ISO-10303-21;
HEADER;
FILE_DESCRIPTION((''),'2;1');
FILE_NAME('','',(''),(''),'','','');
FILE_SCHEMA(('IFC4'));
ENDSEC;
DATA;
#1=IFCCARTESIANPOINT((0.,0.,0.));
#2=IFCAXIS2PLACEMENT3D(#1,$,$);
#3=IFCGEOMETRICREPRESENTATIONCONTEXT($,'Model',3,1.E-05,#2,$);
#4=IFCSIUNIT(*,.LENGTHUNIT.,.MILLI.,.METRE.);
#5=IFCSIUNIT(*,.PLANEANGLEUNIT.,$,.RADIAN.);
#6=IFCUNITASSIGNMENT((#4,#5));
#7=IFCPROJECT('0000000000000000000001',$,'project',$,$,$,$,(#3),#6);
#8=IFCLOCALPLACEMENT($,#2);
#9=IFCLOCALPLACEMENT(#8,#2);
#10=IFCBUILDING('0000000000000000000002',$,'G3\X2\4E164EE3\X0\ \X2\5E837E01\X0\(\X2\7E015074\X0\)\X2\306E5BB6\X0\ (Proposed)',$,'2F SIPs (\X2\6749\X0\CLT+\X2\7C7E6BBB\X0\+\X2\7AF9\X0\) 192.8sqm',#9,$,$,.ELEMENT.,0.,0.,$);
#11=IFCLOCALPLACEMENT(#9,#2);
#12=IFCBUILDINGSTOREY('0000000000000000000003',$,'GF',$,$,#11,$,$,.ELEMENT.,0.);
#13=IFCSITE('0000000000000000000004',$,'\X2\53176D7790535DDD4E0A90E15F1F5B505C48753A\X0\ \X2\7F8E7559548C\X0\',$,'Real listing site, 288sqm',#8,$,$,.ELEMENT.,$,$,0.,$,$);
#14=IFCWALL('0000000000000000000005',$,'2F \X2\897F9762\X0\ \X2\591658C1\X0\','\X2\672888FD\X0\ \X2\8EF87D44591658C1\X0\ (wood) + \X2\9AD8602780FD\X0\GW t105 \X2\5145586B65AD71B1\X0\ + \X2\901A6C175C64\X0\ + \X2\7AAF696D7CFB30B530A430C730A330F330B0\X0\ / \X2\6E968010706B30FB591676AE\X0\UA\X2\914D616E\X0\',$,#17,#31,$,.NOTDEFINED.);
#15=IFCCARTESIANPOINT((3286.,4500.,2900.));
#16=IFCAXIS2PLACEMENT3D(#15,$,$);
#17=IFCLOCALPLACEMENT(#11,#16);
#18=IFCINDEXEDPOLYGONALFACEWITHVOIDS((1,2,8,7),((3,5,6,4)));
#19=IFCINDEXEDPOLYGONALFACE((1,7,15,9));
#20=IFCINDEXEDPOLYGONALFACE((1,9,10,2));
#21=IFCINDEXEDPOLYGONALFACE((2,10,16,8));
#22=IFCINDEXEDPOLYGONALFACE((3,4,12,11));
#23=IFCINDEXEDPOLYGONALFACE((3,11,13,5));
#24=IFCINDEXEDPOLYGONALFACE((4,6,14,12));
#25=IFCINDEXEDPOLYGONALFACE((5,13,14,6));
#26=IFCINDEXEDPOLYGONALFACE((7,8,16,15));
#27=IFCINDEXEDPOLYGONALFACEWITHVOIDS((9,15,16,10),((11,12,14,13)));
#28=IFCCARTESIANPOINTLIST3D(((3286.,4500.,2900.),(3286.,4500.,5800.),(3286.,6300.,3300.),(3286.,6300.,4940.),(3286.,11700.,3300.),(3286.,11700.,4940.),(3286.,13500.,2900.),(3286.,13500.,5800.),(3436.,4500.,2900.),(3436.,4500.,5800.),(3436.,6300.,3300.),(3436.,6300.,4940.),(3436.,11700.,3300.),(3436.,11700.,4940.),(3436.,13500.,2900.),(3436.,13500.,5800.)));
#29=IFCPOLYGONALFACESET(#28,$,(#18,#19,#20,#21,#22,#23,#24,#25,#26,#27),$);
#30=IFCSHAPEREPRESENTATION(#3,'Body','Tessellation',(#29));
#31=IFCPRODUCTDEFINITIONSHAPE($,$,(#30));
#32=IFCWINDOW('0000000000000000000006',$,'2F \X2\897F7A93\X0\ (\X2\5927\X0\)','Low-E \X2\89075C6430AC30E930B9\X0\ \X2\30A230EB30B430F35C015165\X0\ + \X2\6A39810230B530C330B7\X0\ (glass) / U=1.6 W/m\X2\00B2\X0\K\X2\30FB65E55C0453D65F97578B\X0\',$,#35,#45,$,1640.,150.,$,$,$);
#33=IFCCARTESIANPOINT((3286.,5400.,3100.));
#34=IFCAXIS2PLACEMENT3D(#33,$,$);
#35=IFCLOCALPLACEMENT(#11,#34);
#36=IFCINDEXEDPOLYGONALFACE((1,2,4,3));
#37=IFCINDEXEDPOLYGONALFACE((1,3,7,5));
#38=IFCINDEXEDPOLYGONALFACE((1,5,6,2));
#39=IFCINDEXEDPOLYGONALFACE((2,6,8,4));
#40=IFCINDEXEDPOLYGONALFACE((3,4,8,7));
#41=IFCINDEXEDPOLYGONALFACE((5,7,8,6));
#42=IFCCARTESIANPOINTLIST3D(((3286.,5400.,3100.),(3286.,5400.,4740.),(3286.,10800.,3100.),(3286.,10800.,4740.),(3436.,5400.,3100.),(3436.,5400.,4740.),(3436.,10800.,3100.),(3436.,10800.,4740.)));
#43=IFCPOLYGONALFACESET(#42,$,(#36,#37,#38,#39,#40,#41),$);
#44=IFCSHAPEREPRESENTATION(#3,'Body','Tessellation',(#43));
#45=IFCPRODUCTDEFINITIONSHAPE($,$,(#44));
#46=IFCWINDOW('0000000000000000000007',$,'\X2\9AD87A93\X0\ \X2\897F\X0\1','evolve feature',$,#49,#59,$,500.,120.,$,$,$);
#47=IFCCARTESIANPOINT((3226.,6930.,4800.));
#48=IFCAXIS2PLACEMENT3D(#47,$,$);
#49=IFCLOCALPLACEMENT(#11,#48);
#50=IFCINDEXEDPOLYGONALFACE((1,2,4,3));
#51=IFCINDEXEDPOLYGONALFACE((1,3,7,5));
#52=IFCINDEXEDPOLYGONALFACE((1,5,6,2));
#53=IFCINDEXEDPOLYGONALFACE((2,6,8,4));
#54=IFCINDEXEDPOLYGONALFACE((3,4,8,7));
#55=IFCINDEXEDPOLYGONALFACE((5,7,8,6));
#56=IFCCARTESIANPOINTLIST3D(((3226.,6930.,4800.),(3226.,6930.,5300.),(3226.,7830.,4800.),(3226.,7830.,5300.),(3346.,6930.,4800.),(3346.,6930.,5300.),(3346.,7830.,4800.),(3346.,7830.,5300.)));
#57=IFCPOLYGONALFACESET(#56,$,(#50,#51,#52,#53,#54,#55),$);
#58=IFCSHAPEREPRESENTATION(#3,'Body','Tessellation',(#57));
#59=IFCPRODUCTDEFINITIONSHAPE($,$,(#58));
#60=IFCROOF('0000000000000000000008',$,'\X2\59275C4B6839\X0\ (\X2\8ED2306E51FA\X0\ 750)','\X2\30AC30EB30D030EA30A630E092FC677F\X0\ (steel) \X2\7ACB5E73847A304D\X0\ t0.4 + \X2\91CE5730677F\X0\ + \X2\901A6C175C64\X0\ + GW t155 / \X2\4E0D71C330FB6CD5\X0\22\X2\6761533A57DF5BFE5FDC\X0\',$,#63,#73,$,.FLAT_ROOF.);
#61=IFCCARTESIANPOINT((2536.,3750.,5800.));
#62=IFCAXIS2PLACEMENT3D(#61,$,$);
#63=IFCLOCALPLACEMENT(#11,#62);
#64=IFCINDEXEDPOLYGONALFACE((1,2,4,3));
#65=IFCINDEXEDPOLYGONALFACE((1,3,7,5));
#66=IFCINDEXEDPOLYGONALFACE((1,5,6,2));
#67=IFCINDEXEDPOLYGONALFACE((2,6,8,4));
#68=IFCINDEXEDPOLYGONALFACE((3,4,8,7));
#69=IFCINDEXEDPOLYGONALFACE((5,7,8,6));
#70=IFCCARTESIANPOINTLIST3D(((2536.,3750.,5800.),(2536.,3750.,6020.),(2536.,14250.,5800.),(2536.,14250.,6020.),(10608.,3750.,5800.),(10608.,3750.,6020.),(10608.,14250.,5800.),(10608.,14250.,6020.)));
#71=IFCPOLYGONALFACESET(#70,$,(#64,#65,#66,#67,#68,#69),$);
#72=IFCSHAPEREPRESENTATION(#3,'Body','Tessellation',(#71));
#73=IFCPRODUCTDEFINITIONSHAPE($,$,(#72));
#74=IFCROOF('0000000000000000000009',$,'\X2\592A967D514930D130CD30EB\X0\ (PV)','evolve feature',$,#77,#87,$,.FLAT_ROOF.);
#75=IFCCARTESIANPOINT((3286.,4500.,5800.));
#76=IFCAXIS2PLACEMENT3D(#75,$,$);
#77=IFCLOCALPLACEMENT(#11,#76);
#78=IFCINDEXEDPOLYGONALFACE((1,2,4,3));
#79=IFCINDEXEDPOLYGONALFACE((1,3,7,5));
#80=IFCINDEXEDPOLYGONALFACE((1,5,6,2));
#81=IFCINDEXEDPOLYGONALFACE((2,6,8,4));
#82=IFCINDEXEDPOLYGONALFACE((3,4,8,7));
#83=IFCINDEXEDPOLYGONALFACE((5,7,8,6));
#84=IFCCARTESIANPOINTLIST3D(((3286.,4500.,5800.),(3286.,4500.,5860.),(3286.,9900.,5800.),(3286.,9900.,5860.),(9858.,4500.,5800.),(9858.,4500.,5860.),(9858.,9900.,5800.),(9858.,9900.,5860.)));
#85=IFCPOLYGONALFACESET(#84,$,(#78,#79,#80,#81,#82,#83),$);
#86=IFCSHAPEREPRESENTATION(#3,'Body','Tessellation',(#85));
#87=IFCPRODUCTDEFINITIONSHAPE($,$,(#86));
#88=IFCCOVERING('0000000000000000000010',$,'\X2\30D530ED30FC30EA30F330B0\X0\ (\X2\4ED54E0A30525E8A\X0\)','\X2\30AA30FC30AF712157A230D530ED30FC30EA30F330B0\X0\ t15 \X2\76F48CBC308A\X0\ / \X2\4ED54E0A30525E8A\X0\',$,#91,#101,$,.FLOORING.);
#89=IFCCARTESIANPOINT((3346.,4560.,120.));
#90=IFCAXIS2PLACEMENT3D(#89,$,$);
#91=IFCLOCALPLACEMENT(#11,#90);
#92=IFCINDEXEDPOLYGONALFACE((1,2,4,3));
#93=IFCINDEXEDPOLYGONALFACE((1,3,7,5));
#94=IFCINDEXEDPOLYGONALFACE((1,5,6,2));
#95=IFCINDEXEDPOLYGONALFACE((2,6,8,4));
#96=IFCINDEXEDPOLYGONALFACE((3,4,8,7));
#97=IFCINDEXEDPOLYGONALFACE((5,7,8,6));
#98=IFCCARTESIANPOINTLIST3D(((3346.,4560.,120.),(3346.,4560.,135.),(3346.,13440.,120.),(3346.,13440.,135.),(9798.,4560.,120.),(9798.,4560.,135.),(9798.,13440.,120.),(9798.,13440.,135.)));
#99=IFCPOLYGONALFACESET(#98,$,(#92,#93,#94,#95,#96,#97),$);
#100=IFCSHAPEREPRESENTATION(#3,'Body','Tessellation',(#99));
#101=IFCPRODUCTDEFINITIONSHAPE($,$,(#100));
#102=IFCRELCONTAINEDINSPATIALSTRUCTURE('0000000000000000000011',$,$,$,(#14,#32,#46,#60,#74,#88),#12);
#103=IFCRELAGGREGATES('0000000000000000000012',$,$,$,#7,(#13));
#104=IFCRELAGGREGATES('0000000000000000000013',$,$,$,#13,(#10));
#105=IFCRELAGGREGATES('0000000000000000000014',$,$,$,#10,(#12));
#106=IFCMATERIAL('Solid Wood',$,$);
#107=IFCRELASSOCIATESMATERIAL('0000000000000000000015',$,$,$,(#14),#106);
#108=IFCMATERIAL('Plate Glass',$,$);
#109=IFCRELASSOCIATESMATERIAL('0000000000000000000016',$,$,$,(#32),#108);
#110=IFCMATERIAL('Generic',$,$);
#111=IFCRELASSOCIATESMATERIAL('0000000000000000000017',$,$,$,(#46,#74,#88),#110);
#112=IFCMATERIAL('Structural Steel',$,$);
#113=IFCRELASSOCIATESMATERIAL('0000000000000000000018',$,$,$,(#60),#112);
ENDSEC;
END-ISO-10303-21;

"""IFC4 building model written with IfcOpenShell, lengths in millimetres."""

from ifc_helpers import new_model, si_unit, frame, frame_2d, origin, place, context, project, spatial, rectangle, extrude, material, element, fill, save


model = new_model("IFC4")

# Units and contexts
model_context = context("Model", 3, precision=1e-05, world=origin())
ifc_project = project(units=[si_unit("LENGTHUNIT", "METRE", prefix="MILLI"), si_unit("PLANEANGLEUNIT", "RADIAN")], contexts=[model_context])

# Site, building, storey
site_placement = place(None, origin())
site = spatial("IfcSite", under=ifc_project, at=site_placement, Name="北海道川上郡弟子屈町 美留和", ObjectType="Real listing site, 288sqm", CompositionType="ELEMENT", RefElevation=0.0)
building_placement = place(site_placement, origin())
building = spatial("IfcBuilding", under=site, at=building_placement, Name="G3世代 広縁(縁側)の家 (Proposed)", ObjectType="2F SIPs (杉CLT+籾殻+竹) 192.8sqm", CompositionType="ELEMENT", ElevationOfRefHeight=0.0, ElevationOfTerrain=0.0)
storey_placement = place(building_placement, origin())
storey = spatial("IfcBuildingStorey", under=building, at=storey_placement, Name="GF", CompositionType="ELEMENT", Elevation=0.0)

# Shared definitions
ifc_material_1 = material(Name="Solid Wood")

# Shared definitions
ifc_material_2 = material(Name="Plate Glass")
ifc_material_3 = material(Name="Generic")

# Wall, openings, windows
wall_1_placement = place(storey_placement, frame((3286.0, 4500.0, 2900.0)))
wall_1 = element("IfcWall", 1, at=wall_1_placement, inside=storey, material=ifc_material_1, Name="2F 西面 外壁", Description="木製 軸組外壁 (wood) + 高性能GW t105 充填断熱 + 通気層 + 窯業系サイディング / 準耐火・外皮UA配慮", PredefinedType="NOTDEFINED", context=model_context, shape_type="SweptSolid", body=[
    extrude(rectangle(XDim=150.0, YDim=9000.0, at=frame_2d((75.0, 4500.0))), frame((3286.0, 4500.0, 2900.0)), (0.0, 0.0, 1.0), 2900.0),
])
opening_1_placement = place(storey_placement, frame((3286.0, 5400.0, 3100.0)))
opening_1 = element("IfcOpeningElement", 2, at=opening_1_placement, cuts=wall_1, PredefinedType="NOTDEFINED", context=model_context, shape_type="SweptSolid", body=[
    extrude(rectangle(XDim=150.0, YDim=5400.0, at=frame_2d((75.0, 2700.0))), frame((3286.0, 5400.0, 3100.0)), (0.0, 0.0, 1.0), 1640.0),
])
opening_2_placement = place(storey_placement, frame((3226.0, 6930.0, 4800.0)))
opening_2 = element("IfcOpeningElement", 3, at=opening_2_placement, cuts=wall_1, PredefinedType="NOTDEFINED", context=model_context, shape_type="SweptSolid", body=[
    extrude(rectangle(XDim=120.0, YDim=900.0, at=frame_2d((60.0, 450.0))), frame((3226.0, 6930.0, 4800.0)), (0.0, 0.0, 1.0), 500.0),
])
window_1_placement = place(storey_placement, frame((3286.0, 5400.0, 3100.0)))
window_1 = element("IfcWindow", 4, at=window_1_placement, inside=storey, material=ifc_material_2, Name="2F 西窓 (大)", Description="Low-E 複層ガラス アルゴン封入 + 樹脂サッシ (glass) / U=1.6 W/m²K・日射取得型", OverallHeight=1640.0, OverallWidth=150.0, context=model_context, shape_type="SweptSolid", body=[
    extrude(rectangle(XDim=150.0, YDim=5400.0, at=frame_2d((75.0, 2700.0))), frame((3286.0, 5400.0, 3100.0)), (0.0, 0.0, 1.0), 1640.0),
])
fill(opening_1, window_1)
window_2_placement = place(storey_placement, frame((3226.0, 6930.0, 4800.0)))
window_2 = element("IfcWindow", 5, at=window_2_placement, inside=storey, material=ifc_material_3, Name="高窓 西1", Description="evolve feature", OverallHeight=500.0, OverallWidth=120.0, context=model_context, shape_type="SweptSolid", body=[
    extrude(rectangle(XDim=120.0, YDim=900.0, at=frame_2d((60.0, 450.0))), frame((3226.0, 6930.0, 4800.0)), (0.0, 0.0, 1.0), 500.0),
])
fill(opening_2, window_2)

# Roofs
ifc_material_4 = material(Name="Structural Steel")
roof_1_placement = place(storey_placement, frame((2536.0, 3750.0, 5800.0)))
element("IfcRoof", 6, at=roof_1_placement, inside=storey, material=ifc_material_4, Name="大屋根 (軒の出 750)", Description="ガルバリウム鋼板 (steel) 立平葺き t0.4 + 野地板 + 通気層 + GW t155 / 不燃・法22条区域対応", PredefinedType="FLAT_ROOF", context=model_context, shape_type="SweptSolid", body=[
    extrude(rectangle(XDim=8072.0, YDim=10500.0, at=frame_2d((4036.0, 5250.0))), frame((2536.0, 3750.0, 5800.0)), (0.0, 0.0, 1.0), 220.0),
])
roof_2_placement = place(storey_placement, frame((3286.0, 4500.0, 5800.0)))
element("IfcRoof", 7, at=roof_2_placement, inside=storey, material=ifc_material_3, Name="太陽光パネル (PV)", Description="evolve feature", PredefinedType="FLAT_ROOF", context=model_context, shape_type="SweptSolid", body=[
    extrude(rectangle(XDim=6572.0, YDim=5400.0, at=frame_2d((3286.0, 2700.0))), frame((3286.0, 4500.0, 5800.0)), (0.0, 0.0, 1.0), 60.0),
])

# Covering
covering_placement = place(storey_placement, frame((3346.0, 4560.0, 120.0)))
element("IfcCovering", 8, at=covering_placement, inside=storey, material=ifc_material_3, Name="フローリング (仕上げ床)", Description="オーク無垢フローリング t15 直貼り / 仕上げ床", PredefinedType="FLOORING", context=model_context, shape_type="SweptSolid", body=[
    extrude(rectangle(XDim=6452.0, YDim=8880.0, at=frame_2d((3226.0, 4440.0))), frame((3346.0, 4560.0, 120.0)), (0.0, 0.0, 1.0), 15.0),
])

save(model, "model.ifc")
